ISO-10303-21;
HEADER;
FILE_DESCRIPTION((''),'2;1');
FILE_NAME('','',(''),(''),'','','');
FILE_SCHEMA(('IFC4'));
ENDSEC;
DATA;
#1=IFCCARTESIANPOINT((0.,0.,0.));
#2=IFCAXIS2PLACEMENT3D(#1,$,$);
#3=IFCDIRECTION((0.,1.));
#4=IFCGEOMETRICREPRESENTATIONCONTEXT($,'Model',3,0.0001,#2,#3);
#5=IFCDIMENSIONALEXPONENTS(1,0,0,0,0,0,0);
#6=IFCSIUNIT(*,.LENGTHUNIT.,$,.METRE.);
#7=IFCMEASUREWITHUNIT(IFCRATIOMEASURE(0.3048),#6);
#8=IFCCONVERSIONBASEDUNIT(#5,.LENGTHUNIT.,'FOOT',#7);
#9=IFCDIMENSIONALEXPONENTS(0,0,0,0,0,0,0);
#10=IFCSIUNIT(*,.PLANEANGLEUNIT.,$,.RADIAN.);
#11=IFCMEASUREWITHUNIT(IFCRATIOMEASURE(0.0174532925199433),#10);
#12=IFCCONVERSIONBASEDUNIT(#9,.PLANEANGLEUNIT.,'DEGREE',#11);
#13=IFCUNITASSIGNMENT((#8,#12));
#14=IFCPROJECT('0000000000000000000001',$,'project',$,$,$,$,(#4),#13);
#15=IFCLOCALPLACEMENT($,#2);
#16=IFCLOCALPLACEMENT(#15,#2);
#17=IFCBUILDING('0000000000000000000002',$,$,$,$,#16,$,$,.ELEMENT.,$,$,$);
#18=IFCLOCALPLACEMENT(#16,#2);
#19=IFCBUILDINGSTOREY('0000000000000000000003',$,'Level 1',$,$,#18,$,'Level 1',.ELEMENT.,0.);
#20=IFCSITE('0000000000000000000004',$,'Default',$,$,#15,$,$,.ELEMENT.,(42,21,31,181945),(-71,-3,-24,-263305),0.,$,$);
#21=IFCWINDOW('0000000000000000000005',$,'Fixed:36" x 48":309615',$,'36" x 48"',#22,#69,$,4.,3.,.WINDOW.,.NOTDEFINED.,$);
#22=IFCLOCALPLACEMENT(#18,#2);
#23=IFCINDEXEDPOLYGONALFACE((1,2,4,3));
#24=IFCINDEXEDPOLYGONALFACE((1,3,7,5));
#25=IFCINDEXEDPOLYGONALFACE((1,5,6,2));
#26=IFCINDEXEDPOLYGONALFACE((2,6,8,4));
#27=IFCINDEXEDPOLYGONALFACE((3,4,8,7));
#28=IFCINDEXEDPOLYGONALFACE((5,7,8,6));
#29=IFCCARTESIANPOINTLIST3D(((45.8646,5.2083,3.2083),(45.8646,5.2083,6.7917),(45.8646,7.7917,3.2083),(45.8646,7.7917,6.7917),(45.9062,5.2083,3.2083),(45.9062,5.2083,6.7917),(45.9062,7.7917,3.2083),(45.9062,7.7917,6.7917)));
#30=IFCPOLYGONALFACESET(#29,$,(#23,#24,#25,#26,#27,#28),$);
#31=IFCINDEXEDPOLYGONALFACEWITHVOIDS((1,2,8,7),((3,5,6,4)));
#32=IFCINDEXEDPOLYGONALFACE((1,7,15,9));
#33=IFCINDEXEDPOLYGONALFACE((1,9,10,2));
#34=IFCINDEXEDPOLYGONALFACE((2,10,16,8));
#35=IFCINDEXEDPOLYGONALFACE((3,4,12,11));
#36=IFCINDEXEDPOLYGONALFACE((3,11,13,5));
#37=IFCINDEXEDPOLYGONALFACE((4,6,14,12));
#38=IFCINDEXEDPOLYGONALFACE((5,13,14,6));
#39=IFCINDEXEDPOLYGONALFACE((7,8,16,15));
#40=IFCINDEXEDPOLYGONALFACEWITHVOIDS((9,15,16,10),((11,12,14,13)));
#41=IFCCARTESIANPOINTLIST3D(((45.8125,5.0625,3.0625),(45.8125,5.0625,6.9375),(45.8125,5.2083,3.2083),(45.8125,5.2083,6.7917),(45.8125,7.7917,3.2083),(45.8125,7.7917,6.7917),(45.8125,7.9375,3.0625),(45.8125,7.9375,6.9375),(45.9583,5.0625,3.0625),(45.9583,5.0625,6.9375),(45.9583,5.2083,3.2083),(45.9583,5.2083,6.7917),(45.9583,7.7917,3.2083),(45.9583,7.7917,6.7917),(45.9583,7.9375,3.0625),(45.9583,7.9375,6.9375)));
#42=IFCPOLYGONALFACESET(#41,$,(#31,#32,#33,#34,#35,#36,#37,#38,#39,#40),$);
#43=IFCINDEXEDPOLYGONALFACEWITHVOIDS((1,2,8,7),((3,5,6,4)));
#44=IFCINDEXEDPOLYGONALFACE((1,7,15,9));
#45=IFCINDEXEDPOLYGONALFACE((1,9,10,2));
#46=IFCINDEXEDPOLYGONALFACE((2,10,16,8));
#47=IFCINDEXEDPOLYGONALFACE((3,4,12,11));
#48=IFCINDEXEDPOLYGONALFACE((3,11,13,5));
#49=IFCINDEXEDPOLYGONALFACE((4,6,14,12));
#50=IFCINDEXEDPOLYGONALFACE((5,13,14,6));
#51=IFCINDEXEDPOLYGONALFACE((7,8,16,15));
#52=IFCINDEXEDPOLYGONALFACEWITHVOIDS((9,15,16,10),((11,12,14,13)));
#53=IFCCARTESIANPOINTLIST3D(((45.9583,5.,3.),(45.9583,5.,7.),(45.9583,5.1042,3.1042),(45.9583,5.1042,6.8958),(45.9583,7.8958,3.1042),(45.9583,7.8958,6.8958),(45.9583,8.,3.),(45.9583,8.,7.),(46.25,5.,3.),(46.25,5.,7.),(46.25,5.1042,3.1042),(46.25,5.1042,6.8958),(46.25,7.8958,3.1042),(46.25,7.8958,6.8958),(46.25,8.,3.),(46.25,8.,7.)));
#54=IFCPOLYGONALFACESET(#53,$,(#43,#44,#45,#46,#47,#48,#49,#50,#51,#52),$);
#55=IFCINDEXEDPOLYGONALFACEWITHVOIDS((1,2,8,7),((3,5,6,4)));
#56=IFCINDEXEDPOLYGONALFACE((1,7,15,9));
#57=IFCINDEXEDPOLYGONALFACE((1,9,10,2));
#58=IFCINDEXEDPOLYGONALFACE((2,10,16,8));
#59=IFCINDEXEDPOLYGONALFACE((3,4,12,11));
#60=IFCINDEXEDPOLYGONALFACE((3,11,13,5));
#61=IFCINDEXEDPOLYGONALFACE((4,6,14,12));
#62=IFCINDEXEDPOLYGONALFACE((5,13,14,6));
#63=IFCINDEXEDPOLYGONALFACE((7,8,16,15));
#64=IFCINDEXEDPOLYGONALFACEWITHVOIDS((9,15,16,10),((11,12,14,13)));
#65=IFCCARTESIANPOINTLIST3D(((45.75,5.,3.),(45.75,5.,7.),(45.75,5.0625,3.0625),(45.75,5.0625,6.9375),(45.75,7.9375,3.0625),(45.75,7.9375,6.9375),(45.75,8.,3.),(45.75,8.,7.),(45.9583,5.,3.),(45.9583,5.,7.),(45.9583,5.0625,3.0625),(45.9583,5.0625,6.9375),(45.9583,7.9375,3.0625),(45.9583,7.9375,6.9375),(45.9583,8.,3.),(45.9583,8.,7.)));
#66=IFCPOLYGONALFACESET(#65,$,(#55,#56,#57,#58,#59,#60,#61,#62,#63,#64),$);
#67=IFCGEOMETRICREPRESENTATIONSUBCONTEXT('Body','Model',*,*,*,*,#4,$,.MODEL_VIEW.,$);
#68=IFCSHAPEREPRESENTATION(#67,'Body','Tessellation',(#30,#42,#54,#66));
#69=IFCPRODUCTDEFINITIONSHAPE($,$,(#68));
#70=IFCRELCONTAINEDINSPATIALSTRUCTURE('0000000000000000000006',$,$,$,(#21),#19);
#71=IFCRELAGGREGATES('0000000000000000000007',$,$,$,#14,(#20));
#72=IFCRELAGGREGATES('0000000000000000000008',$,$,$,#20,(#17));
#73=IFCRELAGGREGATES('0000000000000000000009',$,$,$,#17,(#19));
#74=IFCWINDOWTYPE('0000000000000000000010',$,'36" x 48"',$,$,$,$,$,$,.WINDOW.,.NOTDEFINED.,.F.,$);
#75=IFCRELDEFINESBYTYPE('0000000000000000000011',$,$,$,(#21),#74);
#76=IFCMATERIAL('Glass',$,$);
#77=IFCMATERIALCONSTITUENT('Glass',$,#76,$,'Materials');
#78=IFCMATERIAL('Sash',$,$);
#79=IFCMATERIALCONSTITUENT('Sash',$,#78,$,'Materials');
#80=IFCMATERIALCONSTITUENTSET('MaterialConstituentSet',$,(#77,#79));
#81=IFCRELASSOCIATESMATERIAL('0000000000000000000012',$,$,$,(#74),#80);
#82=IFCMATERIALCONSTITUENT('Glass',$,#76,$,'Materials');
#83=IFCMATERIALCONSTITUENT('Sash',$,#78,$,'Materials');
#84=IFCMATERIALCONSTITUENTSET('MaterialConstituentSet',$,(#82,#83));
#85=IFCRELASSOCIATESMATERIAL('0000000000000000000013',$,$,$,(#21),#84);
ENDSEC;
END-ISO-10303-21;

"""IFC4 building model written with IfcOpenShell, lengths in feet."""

from ifc_helpers import new_model, entity, si_unit, converted_unit, direction, frame, frame_2d, origin, place, context, subcontext, project, spatial, polyline, rectangle, outline, extrude, source, transform, mapped, material, constituent, constituent_set, type_object, type_shapes, element, save


model = new_model("IFC4")

# Units and contexts
model_context = context("Model", 3, precision=0.0001, world=origin(), true_north=direction((0.0, 1.0)))
body_context = subcontext(model_context, "Body", "Model", "MODEL_VIEW")
ifc_project = project(units=[converted_unit("LENGTHUNIT", "FOOT", entity("IfcRatioMeasure", 0.3048), si_unit("LENGTHUNIT", "METRE"), dimensions=[1, 0, 0, 0, 0, 0, 0]), converted_unit("PLANEANGLEUNIT", "DEGREE", entity("IfcRatioMeasure", 0.0174532925199433), si_unit("PLANEANGLEUNIT", "RADIAN"), dimensions=[0, 0, 0, 0, 0, 0, 0])], contexts=[model_context])

# Site, building, storey
site_placement = place(None, origin())
site = spatial("IfcSite", under=ifc_project, at=site_placement, Name="Default", CompositionType="ELEMENT", RefLatitude=(42, 21, 31, 181945), RefLongitude=(-71, -3, -24, -263305), RefElevation=0.0)
building_placement = place(site_placement, origin())
building = spatial("IfcBuilding", under=site, at=building_placement, CompositionType="ELEMENT")
storey_placement = place(building_placement, origin())
storey = spatial("IfcBuildingStorey", under=building, at=storey_placement, Name="Level 1", LongName="Level 1", CompositionType="ELEMENT", Elevation=0.0)

# Shared definitions
placement_1 = place(storey_placement, frame((46.0, 46.25, 0.0), z_axis=(0.0, 0.0, 1.0), x_axis=(0.0, -1.0, 0.0)))

# Window
ifc_material_1 = material(Name="Glass")
ifc_constituent_1 = constituent(ifc_material_1, Name="Glass", Category="Materials")
ifc_material_2 = material(Name="Sash")
ifc_constituent_2 = constituent(ifc_material_2, Name="Sash", Category="Materials")
ifc_constituent_set_1 = constituent_set(constituents=[ifc_constituent_1, ifc_constituent_2], Name="MaterialConstituentSet")
ifc_constituent_3 = constituent(ifc_material_1, Name="Glass", Category="Materials")
ifc_constituent_4 = constituent(ifc_material_2, Name="Sash", Category="Materials")
ifc_constituent_set_2 = constituent_set(constituents=[ifc_constituent_3, ifc_constituent_4], Name="MaterialConstituentSet")
window_type = type_object("IfcWindowType", Name="36\" x 48\"", ParameterTakesPrecedence=False, PartitioningType="NOTDEFINED", PredefinedType="WINDOW", material=ifc_constituent_set_2)
shared_shape = source(origin(), body_context, "Body", "SweptSolid", [
    extrude(rectangle(XDim=0.0417, YDim=2.5833, at=frame_2d((0.0, 0.0), x_axis=(1.0, 0.0))), frame((1.5, 0.3646, 0.2083), z_axis=(0.0, 0.0, 1.0), x_axis=(0.0, 1.0, 0.0)), (0.0, 0.0, 1.0), 3.5833),
    extrude(outline(polyline([(-1.4375, -1.9375), (1.4375, -1.9375), (1.4375, 1.9375), (-1.4375, 1.9375), (-1.4375, -1.9375)]), holes=[polyline([(-1.2917, -1.7917), (-1.2917, 1.7917), (1.2917, 1.7917), (1.2917, -1.7917), (-1.2917, -1.7917)])]), frame((1.5, 0.2917, 2.0), z_axis=(0.0, 1.0, 0.0), x_axis=(1.0, 0.0, 0.0)), (0.0, 0.0, 1.0), 0.1458),
    extrude(outline(polyline([(-1.5, -2.0), (1.5, -2.0), (1.5, 2.0), (-1.5, 2.0), (-1.5, -2.0)]), holes=[polyline([(-1.3958, -1.8958), (-1.3958, 1.8958), (1.3958, 1.8958), (1.3958, -1.8958), (-1.3958, -1.8958)])]), frame((1.5, 0.0, 2.0), z_axis=(0.0, 1.0, 0.0), x_axis=(1.0, 0.0, 0.0)), (0.0, 0.0, 1.0), 0.2917),
    extrude(outline(polyline([(-2.0, -1.5), (2.0, -1.5), (2.0, 1.5), (-2.0, 1.5), (-2.0, -1.5)]), holes=[polyline([(-1.9375, -1.4375), (-1.9375, 1.4375), (1.9375, 1.4375), (1.9375, -1.4375), (-1.9375, -1.4375)])]), frame((1.5, 0.2917, 2.0), z_axis=(0.0, 1.0, 0.0), x_axis=(0.0, 0.0, -1.0)), (0.0, 0.0, 1.0), 0.2083),
])
type_shapes(window_type, [shared_shape])
placement_2 = place(placement_1, frame((41.25, 0.25, 3.0)))
window_placement = place(placement_2, frame((0.0, 0.0, 0.0), z_axis=(0.0, 0.0, 1.0), x_axis=(-1.0, 0.0, 0.0)))
element("IfcWindow", 1, at=window_placement, inside=storey, type_object=window_type, material=ifc_constituent_set_1, Name="Fixed:36\" x 48\":309615", ObjectType="36\" x 48\"", OverallHeight=4.0, OverallWidth=3.0, PartitioningType="NOTDEFINED", PredefinedType="WINDOW", context=body_context, shape_type="MappedRepresentation", body=[
    mapped(shared_shape, transform((0.0, 0.0, 0.0), scale=1.0)),
])

save(model, "model.ifc")
